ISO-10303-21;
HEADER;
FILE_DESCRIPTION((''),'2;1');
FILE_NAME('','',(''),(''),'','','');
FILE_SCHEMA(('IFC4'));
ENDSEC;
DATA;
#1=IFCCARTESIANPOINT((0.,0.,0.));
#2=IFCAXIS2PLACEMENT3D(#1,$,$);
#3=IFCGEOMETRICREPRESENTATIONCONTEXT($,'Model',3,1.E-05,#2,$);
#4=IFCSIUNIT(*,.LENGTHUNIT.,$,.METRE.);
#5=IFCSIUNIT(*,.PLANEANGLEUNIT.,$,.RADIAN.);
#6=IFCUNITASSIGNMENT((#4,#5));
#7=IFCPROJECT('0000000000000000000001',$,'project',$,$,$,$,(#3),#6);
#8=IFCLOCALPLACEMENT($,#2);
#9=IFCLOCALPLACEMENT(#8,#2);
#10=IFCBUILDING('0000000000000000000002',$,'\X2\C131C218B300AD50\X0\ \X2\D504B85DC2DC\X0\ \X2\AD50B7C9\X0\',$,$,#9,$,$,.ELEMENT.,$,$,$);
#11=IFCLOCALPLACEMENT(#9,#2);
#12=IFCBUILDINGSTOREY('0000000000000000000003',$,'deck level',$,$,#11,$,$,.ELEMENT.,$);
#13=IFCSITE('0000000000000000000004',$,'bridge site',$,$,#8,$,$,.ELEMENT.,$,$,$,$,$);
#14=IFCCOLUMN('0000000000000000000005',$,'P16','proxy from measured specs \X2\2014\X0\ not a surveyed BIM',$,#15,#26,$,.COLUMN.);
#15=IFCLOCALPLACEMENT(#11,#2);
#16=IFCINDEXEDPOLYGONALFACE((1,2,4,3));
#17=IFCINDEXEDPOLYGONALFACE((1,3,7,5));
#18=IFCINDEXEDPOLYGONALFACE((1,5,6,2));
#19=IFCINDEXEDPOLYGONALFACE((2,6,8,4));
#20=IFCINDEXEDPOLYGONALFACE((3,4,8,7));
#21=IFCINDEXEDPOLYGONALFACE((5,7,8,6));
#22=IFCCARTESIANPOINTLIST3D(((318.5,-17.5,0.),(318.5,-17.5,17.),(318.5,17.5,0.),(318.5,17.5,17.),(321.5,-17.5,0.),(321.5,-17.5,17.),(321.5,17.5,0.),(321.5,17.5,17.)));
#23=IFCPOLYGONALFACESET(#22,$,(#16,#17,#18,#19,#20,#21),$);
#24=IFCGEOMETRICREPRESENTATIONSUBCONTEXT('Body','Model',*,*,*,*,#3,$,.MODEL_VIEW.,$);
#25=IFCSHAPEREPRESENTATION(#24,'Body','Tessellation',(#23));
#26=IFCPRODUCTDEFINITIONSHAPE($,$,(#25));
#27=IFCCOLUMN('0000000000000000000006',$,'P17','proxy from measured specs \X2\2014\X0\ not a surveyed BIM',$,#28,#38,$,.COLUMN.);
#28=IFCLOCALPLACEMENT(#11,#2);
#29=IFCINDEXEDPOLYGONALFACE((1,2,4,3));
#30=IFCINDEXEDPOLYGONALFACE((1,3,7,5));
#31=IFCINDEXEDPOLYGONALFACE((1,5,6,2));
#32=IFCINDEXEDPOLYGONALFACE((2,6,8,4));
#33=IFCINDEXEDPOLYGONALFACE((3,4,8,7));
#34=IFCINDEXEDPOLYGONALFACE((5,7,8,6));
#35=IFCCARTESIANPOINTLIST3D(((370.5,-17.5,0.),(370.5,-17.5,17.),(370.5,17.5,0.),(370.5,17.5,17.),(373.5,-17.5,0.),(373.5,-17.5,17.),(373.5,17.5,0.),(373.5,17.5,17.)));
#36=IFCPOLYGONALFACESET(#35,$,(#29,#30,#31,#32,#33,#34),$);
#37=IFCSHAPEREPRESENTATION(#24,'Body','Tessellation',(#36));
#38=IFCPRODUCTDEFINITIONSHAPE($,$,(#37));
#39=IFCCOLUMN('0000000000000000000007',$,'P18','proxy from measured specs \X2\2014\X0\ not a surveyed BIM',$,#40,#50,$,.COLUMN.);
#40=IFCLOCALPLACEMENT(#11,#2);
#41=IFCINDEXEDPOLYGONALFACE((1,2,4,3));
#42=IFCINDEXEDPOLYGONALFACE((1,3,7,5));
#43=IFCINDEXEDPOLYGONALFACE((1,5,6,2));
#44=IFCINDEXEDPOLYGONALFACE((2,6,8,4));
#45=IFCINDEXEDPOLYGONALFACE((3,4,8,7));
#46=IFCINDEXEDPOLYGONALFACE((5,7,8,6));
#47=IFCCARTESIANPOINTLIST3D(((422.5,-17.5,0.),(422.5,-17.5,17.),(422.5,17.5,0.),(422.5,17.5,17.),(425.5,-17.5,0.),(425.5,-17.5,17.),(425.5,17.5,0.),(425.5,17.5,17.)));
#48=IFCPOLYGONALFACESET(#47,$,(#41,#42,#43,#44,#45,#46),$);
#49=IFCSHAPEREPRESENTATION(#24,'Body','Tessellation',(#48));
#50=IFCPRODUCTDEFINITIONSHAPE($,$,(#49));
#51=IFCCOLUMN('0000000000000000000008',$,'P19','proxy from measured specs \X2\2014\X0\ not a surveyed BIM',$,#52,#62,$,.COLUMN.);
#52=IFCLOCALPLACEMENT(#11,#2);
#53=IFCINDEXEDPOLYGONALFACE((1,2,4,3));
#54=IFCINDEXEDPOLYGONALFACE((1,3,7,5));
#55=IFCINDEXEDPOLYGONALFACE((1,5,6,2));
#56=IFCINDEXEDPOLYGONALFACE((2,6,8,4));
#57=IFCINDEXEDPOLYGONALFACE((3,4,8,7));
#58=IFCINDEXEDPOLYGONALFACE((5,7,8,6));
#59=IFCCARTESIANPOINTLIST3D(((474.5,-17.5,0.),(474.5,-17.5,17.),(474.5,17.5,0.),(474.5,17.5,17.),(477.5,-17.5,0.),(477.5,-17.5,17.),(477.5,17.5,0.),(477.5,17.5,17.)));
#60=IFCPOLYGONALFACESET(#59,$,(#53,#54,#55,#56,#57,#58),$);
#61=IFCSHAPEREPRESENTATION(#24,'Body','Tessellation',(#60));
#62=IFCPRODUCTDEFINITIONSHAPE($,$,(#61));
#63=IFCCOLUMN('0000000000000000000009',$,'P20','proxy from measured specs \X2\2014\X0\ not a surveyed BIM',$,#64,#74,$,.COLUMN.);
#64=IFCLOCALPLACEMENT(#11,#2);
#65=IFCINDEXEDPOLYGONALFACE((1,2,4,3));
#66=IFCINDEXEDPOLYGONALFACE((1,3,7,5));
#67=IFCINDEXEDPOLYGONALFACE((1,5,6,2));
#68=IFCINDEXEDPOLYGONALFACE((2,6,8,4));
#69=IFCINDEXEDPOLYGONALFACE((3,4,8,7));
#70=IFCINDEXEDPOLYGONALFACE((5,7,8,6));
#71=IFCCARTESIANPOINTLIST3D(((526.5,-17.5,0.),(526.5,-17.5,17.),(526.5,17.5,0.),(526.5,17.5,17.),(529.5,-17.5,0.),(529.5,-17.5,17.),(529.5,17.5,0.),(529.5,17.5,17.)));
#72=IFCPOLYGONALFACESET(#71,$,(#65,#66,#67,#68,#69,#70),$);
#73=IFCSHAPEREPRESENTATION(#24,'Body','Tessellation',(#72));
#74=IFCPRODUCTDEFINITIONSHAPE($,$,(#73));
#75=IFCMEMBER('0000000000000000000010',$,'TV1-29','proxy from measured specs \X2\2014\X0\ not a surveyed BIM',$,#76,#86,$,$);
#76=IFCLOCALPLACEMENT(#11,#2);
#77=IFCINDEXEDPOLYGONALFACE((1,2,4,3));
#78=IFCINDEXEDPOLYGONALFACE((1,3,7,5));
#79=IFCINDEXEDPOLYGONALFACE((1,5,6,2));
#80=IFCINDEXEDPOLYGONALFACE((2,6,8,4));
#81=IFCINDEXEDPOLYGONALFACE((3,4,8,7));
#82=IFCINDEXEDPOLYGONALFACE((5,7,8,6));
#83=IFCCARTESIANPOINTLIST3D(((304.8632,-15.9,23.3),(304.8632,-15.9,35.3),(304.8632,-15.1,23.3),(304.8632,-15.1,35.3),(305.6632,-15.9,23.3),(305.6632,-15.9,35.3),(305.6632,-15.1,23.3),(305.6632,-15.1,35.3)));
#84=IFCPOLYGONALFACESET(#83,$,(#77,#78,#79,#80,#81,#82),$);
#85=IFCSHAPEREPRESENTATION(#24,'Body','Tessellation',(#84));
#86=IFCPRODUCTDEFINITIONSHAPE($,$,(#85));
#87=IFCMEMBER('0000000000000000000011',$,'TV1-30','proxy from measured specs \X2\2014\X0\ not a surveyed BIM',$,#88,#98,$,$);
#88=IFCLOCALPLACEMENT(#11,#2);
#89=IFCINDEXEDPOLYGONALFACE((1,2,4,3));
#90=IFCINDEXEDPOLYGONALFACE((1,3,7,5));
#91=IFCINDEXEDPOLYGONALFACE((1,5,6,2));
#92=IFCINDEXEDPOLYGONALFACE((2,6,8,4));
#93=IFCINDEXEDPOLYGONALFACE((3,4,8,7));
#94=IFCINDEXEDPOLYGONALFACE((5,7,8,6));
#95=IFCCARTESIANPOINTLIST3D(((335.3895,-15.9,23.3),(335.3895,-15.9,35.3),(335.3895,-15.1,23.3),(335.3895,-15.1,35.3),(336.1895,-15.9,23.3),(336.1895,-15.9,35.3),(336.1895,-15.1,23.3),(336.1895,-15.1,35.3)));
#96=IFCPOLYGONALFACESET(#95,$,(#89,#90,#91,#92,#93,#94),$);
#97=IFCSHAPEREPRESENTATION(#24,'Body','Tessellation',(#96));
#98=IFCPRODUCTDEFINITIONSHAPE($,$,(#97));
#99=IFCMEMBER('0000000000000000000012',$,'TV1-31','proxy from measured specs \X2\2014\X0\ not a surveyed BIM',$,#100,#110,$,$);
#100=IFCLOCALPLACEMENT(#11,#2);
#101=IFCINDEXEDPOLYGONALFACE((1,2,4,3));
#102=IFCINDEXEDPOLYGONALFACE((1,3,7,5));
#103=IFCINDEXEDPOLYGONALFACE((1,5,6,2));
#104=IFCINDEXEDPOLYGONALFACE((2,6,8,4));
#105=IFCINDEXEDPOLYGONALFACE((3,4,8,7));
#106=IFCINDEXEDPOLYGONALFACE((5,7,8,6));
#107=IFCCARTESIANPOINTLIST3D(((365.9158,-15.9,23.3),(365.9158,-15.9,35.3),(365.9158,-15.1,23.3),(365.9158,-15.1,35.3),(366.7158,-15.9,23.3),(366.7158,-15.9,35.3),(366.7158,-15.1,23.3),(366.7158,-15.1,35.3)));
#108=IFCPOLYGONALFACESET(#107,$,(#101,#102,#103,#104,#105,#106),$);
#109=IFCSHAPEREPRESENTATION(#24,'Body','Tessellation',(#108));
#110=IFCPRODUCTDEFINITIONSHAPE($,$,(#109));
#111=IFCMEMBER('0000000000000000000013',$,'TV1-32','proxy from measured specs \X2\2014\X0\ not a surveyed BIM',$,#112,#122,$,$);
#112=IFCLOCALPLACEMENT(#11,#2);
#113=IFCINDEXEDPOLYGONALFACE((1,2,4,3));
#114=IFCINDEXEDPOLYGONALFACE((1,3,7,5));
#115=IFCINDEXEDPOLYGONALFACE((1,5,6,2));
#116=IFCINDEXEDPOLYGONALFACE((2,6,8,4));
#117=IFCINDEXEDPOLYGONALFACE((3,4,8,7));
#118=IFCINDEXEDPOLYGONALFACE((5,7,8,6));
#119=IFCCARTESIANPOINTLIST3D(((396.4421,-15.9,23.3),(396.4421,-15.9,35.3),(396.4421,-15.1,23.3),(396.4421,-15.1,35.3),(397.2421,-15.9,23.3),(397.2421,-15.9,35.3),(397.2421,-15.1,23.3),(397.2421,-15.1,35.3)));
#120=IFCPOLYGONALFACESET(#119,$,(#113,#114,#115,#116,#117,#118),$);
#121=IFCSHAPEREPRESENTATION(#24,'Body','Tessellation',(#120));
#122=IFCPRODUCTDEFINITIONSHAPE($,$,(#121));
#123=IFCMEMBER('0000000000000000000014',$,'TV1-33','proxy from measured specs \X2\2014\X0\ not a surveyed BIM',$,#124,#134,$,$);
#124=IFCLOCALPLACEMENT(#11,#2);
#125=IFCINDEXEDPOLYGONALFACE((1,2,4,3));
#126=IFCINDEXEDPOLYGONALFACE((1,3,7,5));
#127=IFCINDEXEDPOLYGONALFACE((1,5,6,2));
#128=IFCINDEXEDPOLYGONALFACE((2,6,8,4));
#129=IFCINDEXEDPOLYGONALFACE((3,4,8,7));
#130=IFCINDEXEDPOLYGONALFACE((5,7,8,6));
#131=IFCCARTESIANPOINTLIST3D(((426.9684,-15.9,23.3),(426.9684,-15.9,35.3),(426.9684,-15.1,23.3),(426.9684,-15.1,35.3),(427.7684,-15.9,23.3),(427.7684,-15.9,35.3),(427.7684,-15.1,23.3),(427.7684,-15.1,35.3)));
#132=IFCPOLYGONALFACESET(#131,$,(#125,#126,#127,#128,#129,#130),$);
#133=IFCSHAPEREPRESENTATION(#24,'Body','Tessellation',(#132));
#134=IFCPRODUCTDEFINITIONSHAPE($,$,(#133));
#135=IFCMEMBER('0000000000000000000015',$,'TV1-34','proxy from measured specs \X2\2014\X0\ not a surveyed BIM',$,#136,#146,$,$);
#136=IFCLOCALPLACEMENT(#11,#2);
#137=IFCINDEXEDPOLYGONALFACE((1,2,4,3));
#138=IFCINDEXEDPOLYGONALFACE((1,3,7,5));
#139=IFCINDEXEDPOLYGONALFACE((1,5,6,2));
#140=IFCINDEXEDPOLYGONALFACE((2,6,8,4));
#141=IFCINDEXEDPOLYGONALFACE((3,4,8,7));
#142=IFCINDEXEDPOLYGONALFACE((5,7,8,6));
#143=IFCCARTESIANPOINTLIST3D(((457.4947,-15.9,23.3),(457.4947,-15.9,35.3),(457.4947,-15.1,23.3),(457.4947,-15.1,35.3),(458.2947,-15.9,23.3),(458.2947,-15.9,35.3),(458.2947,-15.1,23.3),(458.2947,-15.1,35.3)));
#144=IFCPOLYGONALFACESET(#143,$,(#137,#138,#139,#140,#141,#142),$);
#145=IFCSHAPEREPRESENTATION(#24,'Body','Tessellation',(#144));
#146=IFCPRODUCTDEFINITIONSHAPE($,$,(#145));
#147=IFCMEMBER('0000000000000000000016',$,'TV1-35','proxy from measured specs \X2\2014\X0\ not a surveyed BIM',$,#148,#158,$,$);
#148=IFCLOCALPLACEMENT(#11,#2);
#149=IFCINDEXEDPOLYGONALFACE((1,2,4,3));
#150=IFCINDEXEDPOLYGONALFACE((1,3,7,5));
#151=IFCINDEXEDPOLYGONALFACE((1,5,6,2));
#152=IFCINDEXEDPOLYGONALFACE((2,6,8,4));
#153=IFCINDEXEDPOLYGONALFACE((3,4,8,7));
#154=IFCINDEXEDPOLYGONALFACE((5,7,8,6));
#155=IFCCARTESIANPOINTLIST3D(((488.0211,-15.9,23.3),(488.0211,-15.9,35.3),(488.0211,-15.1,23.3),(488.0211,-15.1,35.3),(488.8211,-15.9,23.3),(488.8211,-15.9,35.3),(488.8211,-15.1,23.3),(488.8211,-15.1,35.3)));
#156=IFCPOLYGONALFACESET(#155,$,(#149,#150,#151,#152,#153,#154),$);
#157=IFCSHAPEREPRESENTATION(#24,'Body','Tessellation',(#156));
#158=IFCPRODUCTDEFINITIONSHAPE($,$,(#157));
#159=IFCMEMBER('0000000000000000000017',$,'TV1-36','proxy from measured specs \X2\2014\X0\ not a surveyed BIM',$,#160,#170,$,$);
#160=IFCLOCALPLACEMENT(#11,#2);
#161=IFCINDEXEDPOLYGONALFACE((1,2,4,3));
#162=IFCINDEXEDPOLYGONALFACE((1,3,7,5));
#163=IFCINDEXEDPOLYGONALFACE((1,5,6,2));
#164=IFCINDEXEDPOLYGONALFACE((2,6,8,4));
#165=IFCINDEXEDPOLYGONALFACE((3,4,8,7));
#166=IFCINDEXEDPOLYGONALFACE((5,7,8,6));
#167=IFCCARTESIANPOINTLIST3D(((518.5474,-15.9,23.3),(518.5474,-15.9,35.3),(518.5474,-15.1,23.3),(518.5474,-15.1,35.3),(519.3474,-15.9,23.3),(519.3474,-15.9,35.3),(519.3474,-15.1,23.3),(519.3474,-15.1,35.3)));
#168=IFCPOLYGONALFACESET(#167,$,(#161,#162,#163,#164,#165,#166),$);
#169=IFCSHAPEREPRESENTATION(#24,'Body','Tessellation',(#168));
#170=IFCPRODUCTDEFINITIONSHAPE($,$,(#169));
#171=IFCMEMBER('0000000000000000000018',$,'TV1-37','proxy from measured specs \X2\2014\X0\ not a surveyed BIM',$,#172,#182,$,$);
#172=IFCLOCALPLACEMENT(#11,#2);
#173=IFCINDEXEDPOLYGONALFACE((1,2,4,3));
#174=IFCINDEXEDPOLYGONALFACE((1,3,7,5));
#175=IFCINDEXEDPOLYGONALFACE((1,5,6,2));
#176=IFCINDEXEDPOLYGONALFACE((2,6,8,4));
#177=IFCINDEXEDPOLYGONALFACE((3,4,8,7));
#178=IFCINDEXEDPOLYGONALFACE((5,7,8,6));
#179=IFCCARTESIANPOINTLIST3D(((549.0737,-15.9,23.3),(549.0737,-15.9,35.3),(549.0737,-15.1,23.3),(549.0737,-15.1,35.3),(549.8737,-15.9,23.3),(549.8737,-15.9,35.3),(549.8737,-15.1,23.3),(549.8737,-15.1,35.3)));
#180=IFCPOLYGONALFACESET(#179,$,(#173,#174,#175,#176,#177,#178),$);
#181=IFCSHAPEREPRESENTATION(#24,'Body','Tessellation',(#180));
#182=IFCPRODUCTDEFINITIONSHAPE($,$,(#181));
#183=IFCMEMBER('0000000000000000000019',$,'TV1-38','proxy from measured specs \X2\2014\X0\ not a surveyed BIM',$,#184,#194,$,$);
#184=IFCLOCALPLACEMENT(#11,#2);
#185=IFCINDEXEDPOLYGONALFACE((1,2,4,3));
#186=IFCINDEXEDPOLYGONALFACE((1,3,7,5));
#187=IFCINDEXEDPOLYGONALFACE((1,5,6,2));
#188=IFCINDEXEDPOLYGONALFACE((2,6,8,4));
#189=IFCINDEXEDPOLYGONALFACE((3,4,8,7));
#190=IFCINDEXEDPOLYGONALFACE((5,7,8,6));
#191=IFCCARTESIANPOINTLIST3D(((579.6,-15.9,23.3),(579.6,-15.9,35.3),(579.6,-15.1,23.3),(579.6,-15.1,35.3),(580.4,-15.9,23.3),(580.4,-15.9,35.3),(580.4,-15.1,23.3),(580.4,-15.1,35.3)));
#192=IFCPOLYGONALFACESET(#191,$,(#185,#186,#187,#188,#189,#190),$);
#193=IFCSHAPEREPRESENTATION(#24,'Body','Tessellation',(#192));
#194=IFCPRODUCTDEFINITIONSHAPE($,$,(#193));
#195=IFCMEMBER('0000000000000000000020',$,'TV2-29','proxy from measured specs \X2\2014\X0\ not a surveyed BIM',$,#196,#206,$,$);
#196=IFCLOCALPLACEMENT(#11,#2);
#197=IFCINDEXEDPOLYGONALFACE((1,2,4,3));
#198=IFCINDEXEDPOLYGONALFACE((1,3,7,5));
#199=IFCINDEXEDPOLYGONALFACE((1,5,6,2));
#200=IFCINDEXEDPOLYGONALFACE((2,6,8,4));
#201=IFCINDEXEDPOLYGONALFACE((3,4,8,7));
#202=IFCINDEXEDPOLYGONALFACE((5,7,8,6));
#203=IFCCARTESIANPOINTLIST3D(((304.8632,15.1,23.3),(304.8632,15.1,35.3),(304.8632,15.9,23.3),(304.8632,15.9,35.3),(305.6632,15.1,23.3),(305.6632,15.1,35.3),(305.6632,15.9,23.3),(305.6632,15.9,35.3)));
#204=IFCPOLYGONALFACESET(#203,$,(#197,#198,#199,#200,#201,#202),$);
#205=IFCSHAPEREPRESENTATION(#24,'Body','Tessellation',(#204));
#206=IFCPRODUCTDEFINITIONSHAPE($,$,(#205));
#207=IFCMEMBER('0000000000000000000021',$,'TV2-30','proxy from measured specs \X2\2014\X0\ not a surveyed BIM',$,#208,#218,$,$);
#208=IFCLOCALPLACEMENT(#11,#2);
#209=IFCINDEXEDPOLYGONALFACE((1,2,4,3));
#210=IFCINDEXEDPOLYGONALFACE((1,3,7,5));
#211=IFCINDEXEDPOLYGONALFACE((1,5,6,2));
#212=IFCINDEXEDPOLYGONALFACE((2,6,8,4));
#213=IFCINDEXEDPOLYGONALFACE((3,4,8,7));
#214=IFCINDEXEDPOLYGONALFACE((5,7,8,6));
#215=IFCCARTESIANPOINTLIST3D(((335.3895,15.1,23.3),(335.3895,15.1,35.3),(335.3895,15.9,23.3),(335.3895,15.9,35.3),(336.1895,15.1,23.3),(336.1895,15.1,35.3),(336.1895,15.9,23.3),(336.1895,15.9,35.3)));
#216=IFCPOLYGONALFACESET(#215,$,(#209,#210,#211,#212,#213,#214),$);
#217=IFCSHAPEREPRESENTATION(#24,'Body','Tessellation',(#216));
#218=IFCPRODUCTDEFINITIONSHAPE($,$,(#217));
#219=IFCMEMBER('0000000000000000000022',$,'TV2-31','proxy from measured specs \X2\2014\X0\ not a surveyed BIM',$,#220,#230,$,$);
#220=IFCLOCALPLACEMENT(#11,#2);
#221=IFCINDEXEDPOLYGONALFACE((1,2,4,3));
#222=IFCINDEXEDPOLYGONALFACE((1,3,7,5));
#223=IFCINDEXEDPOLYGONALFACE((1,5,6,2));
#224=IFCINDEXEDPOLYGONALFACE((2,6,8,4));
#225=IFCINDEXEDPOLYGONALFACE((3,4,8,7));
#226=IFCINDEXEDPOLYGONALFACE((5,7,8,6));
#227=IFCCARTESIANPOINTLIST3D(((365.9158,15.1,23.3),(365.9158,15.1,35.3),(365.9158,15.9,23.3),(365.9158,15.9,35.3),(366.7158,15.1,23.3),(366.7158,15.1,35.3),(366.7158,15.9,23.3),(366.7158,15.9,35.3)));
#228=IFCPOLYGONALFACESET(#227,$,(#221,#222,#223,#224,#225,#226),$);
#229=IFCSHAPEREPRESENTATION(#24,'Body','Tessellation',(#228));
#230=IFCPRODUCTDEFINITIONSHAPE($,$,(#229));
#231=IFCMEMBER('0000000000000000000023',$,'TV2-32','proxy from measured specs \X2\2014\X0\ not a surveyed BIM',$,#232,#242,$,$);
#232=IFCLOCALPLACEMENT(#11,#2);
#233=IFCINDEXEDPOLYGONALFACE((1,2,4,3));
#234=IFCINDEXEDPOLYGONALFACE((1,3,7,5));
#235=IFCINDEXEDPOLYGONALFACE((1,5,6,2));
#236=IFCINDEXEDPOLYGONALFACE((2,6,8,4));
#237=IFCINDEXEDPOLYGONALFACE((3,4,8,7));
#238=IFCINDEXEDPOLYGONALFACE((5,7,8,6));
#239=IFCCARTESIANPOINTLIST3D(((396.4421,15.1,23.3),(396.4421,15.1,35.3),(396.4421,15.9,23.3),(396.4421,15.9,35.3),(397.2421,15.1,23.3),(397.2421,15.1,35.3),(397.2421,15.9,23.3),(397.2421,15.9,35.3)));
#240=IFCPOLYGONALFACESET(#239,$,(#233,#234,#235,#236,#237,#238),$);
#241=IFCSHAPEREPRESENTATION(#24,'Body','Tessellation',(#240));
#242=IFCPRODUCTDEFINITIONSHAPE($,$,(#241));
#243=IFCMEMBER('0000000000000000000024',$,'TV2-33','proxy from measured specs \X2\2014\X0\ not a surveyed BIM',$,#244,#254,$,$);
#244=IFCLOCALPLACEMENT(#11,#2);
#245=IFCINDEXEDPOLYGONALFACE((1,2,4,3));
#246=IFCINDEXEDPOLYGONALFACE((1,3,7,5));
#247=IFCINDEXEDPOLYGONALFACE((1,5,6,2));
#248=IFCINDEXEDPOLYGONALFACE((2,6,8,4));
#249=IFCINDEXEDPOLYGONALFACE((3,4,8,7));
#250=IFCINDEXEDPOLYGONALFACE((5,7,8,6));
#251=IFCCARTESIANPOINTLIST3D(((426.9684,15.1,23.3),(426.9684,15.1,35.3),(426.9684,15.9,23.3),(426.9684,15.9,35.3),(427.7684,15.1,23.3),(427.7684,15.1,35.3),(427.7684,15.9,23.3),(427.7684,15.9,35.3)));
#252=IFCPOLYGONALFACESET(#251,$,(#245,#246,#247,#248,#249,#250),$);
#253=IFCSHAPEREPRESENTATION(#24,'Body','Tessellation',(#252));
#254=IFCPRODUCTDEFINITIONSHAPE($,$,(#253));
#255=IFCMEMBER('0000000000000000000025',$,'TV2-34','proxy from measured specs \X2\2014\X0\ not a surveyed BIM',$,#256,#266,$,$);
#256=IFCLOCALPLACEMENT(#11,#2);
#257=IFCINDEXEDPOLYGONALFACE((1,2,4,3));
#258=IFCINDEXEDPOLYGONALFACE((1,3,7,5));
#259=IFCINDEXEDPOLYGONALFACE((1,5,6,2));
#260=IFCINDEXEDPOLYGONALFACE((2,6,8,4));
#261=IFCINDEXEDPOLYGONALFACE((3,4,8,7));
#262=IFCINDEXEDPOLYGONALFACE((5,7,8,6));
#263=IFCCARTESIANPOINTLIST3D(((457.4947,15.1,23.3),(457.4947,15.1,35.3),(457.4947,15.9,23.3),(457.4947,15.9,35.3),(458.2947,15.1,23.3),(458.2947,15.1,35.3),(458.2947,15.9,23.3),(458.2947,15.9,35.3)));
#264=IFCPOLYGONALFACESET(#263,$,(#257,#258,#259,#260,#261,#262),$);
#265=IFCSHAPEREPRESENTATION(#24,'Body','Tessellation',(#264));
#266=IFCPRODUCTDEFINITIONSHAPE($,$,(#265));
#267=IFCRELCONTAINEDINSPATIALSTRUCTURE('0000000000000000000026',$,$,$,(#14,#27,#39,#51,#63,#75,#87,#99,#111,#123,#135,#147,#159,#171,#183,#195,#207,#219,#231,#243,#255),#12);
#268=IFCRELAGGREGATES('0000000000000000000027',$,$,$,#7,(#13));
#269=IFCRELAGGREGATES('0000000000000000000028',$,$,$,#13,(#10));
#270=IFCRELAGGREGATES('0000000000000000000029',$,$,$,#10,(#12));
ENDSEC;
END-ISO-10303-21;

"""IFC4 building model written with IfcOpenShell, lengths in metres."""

from ifc_helpers import new_model, si_unit, frame, origin, origin_2d, place, context, subcontext, project, spatial, rectangle, extrude, element, save


model = new_model("IFC4")

# Units and contexts
model_context = context("Model", 3, precision=1e-05, world=origin())
body_context = subcontext(model_context, "Body", "Model", "MODEL_VIEW")
ifc_project = project(units=[si_unit("LENGTHUNIT", "METRE"), si_unit("PLANEANGLEUNIT", "RADIAN")], contexts=[model_context])

# Site, building, storey
site_placement = place(None, origin())
site = spatial("IfcSite", under=ifc_project, at=site_placement, Name="bridge site", CompositionType="ELEMENT")
building_placement = place(site_placement, origin())
building = spatial("IfcBuilding", under=site, at=building_placement, Name="성수대교 프록시 교량", CompositionType="ELEMENT")
storey_placement = place(building_placement, origin())
storey = spatial("IfcBuildingStorey", under=building, at=storey_placement, Name="deck level", CompositionType="ELEMENT")

# Columns
for number, where, name in (
    (1, (320.0, 0.0, 0.0), "P16"),
    (2, (372.0, 0.0, 0.0), "P17"),
    (3, (424.0, 0.0, 0.0), "P18"),
    (4, (476.0, 0.0, 0.0), "P19"),
    (5, (528.0, 0.0, 0.0), "P20"),
):
    element("IfcColumn", number, at=place(storey_placement, frame(where)), inside=storey, Name=name, Description="proxy from measured specs — not a surveyed BIM", PredefinedType="COLUMN", context=body_context, shape_type="SweptSolid", body=[
        extrude(rectangle(XDim=3.0, YDim=35.0, at=origin_2d()), origin(), (0.0, 0.0, 1.0), 17.0),
    ])

# Members
for number, where, name in (
    (6, (305.2632, -15.5, 23.3), "TV1-29"),
    (7, (335.7895, -15.5, 23.3), "TV1-30"),
    (8, (366.3158, -15.5, 23.3), "TV1-31"),
    (9, (396.8421, -15.5, 23.3), "TV1-32"),
    (10, (427.3684, -15.5, 23.3), "TV1-33"),
    (11, (457.8947, -15.5, 23.3), "TV1-34"),
    (12, (488.4211, -15.5, 23.3), "TV1-35"),
    (13, (518.9474, -15.5, 23.3), "TV1-36"),
    (14, (549.4737, -15.5, 23.3), "TV1-37"),
    (15, (580.0, -15.5, 23.3), "TV1-38"),
    (16, (305.2632, 15.5, 23.3), "TV2-29"),
    (17, (335.7895, 15.5, 23.3), "TV2-30"),
    (18, (366.3158, 15.5, 23.3), "TV2-31"),
    (19, (396.8421, 15.5, 23.3), "TV2-32"),
    (20, (427.3684, 15.5, 23.3), "TV2-33"),
    (21, (457.8947, 15.5, 23.3), "TV2-34"),
):
    element("IfcMember", number, at=place(storey_placement, frame(where)), inside=storey, Name=name, Description="proxy from measured specs — not a surveyed BIM", context=body_context, shape_type="SweptSolid", body=[
        extrude(rectangle(XDim=0.8, YDim=0.8, at=origin_2d()), origin(), (0.0, 0.0, 1.0), 12.0),
    ])

save(model, "model.ifc")
